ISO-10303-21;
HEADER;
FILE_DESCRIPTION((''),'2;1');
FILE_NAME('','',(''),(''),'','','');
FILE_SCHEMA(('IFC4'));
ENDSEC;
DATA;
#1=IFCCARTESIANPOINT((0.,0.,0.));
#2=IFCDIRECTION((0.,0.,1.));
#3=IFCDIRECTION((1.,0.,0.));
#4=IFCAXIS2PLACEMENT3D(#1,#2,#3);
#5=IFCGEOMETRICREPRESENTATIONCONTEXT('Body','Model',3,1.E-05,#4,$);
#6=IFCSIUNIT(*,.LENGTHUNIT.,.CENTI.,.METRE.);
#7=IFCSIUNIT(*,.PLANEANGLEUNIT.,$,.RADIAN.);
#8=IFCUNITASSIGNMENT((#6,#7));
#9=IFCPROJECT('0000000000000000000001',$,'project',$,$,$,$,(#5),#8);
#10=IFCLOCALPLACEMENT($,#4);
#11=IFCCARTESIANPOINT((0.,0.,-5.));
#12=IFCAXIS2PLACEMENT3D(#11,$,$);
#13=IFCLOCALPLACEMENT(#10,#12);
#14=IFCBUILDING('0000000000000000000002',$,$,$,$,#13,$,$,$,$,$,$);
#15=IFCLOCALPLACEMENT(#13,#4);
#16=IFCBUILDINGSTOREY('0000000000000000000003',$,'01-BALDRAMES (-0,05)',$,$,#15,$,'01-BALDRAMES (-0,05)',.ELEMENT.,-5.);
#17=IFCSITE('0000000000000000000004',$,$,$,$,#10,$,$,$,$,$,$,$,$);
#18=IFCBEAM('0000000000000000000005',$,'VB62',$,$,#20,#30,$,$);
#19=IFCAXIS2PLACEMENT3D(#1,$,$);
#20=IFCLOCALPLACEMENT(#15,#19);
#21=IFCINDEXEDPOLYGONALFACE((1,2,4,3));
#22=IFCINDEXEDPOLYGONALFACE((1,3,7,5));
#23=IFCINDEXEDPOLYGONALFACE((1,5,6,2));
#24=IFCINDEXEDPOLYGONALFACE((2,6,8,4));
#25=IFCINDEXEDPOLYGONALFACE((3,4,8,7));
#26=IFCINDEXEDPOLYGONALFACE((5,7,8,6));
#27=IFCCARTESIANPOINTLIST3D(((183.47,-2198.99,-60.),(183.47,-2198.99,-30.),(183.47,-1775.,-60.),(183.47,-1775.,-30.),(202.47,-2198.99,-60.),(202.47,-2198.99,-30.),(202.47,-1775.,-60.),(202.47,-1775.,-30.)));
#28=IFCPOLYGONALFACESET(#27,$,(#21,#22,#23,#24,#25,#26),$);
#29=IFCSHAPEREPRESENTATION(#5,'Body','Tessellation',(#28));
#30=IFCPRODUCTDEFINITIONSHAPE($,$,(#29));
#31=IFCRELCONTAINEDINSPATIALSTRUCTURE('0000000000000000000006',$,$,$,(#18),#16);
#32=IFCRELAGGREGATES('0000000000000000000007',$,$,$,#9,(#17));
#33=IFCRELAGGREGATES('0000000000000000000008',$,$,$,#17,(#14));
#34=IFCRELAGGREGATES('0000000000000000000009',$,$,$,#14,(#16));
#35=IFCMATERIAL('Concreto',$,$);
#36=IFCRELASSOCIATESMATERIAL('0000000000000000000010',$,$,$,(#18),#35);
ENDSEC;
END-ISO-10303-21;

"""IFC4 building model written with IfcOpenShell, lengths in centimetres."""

from ifc_helpers import new_model, si_unit, frame, origin_with_axes, origin_2d_with_axis, place, context, project, spatial, rectangle, extrude, material, element, save


model = new_model("IFC4")

# Units and contexts
model_context = context("Model", 3, precision=1e-05, world=origin_with_axes(), identifier="Body")
ifc_project = project(units=[si_unit("LENGTHUNIT", "METRE", prefix="CENTI"), si_unit("PLANEANGLEUNIT", "RADIAN")], contexts=[model_context])

# Site, building, storey
site_placement = place(None, origin_with_axes())
site = spatial("IfcSite", under=ifc_project, at=site_placement)
building_placement = place(site_placement, frame((0.0, 0.0, -5.0)))
building = spatial("IfcBuilding", under=site, at=building_placement)
storey_placement = place(building_placement, origin_with_axes())
storey = spatial("IfcBuildingStorey", under=building, at=storey_placement, Name="01-BALDRAMES (-0,05)", LongName="01-BALDRAMES (-0,05)", CompositionType="ELEMENT", Elevation=-5.0)

# Shared definitions
ifc_material = material(Name="Concreto")

# Beam
beam_1_placement = place(storey_placement, frame((192.97, -1986.99, -30.0), z_axis=(0.0, 0.0, 1.0), x_axis=(1.0, 0.0, 0.0)))
element("IfcBeam", 1, at=beam_1_placement, inside=storey, material=ifc_material, Name="VB62", context=model_context, shape_type="SolidModel", body=[
    extrude(rectangle(XDim=19.0, YDim=30.0, at=origin_2d_with_axis()), frame((0.0, -212.0, -15.0), z_axis=(0.0, 1.0, 0.0), x_axis=(1.0, 0.0, 0.0)), (0.0, 0.0, 1.0), 423.99),
])

save(model, "model.ifc")
